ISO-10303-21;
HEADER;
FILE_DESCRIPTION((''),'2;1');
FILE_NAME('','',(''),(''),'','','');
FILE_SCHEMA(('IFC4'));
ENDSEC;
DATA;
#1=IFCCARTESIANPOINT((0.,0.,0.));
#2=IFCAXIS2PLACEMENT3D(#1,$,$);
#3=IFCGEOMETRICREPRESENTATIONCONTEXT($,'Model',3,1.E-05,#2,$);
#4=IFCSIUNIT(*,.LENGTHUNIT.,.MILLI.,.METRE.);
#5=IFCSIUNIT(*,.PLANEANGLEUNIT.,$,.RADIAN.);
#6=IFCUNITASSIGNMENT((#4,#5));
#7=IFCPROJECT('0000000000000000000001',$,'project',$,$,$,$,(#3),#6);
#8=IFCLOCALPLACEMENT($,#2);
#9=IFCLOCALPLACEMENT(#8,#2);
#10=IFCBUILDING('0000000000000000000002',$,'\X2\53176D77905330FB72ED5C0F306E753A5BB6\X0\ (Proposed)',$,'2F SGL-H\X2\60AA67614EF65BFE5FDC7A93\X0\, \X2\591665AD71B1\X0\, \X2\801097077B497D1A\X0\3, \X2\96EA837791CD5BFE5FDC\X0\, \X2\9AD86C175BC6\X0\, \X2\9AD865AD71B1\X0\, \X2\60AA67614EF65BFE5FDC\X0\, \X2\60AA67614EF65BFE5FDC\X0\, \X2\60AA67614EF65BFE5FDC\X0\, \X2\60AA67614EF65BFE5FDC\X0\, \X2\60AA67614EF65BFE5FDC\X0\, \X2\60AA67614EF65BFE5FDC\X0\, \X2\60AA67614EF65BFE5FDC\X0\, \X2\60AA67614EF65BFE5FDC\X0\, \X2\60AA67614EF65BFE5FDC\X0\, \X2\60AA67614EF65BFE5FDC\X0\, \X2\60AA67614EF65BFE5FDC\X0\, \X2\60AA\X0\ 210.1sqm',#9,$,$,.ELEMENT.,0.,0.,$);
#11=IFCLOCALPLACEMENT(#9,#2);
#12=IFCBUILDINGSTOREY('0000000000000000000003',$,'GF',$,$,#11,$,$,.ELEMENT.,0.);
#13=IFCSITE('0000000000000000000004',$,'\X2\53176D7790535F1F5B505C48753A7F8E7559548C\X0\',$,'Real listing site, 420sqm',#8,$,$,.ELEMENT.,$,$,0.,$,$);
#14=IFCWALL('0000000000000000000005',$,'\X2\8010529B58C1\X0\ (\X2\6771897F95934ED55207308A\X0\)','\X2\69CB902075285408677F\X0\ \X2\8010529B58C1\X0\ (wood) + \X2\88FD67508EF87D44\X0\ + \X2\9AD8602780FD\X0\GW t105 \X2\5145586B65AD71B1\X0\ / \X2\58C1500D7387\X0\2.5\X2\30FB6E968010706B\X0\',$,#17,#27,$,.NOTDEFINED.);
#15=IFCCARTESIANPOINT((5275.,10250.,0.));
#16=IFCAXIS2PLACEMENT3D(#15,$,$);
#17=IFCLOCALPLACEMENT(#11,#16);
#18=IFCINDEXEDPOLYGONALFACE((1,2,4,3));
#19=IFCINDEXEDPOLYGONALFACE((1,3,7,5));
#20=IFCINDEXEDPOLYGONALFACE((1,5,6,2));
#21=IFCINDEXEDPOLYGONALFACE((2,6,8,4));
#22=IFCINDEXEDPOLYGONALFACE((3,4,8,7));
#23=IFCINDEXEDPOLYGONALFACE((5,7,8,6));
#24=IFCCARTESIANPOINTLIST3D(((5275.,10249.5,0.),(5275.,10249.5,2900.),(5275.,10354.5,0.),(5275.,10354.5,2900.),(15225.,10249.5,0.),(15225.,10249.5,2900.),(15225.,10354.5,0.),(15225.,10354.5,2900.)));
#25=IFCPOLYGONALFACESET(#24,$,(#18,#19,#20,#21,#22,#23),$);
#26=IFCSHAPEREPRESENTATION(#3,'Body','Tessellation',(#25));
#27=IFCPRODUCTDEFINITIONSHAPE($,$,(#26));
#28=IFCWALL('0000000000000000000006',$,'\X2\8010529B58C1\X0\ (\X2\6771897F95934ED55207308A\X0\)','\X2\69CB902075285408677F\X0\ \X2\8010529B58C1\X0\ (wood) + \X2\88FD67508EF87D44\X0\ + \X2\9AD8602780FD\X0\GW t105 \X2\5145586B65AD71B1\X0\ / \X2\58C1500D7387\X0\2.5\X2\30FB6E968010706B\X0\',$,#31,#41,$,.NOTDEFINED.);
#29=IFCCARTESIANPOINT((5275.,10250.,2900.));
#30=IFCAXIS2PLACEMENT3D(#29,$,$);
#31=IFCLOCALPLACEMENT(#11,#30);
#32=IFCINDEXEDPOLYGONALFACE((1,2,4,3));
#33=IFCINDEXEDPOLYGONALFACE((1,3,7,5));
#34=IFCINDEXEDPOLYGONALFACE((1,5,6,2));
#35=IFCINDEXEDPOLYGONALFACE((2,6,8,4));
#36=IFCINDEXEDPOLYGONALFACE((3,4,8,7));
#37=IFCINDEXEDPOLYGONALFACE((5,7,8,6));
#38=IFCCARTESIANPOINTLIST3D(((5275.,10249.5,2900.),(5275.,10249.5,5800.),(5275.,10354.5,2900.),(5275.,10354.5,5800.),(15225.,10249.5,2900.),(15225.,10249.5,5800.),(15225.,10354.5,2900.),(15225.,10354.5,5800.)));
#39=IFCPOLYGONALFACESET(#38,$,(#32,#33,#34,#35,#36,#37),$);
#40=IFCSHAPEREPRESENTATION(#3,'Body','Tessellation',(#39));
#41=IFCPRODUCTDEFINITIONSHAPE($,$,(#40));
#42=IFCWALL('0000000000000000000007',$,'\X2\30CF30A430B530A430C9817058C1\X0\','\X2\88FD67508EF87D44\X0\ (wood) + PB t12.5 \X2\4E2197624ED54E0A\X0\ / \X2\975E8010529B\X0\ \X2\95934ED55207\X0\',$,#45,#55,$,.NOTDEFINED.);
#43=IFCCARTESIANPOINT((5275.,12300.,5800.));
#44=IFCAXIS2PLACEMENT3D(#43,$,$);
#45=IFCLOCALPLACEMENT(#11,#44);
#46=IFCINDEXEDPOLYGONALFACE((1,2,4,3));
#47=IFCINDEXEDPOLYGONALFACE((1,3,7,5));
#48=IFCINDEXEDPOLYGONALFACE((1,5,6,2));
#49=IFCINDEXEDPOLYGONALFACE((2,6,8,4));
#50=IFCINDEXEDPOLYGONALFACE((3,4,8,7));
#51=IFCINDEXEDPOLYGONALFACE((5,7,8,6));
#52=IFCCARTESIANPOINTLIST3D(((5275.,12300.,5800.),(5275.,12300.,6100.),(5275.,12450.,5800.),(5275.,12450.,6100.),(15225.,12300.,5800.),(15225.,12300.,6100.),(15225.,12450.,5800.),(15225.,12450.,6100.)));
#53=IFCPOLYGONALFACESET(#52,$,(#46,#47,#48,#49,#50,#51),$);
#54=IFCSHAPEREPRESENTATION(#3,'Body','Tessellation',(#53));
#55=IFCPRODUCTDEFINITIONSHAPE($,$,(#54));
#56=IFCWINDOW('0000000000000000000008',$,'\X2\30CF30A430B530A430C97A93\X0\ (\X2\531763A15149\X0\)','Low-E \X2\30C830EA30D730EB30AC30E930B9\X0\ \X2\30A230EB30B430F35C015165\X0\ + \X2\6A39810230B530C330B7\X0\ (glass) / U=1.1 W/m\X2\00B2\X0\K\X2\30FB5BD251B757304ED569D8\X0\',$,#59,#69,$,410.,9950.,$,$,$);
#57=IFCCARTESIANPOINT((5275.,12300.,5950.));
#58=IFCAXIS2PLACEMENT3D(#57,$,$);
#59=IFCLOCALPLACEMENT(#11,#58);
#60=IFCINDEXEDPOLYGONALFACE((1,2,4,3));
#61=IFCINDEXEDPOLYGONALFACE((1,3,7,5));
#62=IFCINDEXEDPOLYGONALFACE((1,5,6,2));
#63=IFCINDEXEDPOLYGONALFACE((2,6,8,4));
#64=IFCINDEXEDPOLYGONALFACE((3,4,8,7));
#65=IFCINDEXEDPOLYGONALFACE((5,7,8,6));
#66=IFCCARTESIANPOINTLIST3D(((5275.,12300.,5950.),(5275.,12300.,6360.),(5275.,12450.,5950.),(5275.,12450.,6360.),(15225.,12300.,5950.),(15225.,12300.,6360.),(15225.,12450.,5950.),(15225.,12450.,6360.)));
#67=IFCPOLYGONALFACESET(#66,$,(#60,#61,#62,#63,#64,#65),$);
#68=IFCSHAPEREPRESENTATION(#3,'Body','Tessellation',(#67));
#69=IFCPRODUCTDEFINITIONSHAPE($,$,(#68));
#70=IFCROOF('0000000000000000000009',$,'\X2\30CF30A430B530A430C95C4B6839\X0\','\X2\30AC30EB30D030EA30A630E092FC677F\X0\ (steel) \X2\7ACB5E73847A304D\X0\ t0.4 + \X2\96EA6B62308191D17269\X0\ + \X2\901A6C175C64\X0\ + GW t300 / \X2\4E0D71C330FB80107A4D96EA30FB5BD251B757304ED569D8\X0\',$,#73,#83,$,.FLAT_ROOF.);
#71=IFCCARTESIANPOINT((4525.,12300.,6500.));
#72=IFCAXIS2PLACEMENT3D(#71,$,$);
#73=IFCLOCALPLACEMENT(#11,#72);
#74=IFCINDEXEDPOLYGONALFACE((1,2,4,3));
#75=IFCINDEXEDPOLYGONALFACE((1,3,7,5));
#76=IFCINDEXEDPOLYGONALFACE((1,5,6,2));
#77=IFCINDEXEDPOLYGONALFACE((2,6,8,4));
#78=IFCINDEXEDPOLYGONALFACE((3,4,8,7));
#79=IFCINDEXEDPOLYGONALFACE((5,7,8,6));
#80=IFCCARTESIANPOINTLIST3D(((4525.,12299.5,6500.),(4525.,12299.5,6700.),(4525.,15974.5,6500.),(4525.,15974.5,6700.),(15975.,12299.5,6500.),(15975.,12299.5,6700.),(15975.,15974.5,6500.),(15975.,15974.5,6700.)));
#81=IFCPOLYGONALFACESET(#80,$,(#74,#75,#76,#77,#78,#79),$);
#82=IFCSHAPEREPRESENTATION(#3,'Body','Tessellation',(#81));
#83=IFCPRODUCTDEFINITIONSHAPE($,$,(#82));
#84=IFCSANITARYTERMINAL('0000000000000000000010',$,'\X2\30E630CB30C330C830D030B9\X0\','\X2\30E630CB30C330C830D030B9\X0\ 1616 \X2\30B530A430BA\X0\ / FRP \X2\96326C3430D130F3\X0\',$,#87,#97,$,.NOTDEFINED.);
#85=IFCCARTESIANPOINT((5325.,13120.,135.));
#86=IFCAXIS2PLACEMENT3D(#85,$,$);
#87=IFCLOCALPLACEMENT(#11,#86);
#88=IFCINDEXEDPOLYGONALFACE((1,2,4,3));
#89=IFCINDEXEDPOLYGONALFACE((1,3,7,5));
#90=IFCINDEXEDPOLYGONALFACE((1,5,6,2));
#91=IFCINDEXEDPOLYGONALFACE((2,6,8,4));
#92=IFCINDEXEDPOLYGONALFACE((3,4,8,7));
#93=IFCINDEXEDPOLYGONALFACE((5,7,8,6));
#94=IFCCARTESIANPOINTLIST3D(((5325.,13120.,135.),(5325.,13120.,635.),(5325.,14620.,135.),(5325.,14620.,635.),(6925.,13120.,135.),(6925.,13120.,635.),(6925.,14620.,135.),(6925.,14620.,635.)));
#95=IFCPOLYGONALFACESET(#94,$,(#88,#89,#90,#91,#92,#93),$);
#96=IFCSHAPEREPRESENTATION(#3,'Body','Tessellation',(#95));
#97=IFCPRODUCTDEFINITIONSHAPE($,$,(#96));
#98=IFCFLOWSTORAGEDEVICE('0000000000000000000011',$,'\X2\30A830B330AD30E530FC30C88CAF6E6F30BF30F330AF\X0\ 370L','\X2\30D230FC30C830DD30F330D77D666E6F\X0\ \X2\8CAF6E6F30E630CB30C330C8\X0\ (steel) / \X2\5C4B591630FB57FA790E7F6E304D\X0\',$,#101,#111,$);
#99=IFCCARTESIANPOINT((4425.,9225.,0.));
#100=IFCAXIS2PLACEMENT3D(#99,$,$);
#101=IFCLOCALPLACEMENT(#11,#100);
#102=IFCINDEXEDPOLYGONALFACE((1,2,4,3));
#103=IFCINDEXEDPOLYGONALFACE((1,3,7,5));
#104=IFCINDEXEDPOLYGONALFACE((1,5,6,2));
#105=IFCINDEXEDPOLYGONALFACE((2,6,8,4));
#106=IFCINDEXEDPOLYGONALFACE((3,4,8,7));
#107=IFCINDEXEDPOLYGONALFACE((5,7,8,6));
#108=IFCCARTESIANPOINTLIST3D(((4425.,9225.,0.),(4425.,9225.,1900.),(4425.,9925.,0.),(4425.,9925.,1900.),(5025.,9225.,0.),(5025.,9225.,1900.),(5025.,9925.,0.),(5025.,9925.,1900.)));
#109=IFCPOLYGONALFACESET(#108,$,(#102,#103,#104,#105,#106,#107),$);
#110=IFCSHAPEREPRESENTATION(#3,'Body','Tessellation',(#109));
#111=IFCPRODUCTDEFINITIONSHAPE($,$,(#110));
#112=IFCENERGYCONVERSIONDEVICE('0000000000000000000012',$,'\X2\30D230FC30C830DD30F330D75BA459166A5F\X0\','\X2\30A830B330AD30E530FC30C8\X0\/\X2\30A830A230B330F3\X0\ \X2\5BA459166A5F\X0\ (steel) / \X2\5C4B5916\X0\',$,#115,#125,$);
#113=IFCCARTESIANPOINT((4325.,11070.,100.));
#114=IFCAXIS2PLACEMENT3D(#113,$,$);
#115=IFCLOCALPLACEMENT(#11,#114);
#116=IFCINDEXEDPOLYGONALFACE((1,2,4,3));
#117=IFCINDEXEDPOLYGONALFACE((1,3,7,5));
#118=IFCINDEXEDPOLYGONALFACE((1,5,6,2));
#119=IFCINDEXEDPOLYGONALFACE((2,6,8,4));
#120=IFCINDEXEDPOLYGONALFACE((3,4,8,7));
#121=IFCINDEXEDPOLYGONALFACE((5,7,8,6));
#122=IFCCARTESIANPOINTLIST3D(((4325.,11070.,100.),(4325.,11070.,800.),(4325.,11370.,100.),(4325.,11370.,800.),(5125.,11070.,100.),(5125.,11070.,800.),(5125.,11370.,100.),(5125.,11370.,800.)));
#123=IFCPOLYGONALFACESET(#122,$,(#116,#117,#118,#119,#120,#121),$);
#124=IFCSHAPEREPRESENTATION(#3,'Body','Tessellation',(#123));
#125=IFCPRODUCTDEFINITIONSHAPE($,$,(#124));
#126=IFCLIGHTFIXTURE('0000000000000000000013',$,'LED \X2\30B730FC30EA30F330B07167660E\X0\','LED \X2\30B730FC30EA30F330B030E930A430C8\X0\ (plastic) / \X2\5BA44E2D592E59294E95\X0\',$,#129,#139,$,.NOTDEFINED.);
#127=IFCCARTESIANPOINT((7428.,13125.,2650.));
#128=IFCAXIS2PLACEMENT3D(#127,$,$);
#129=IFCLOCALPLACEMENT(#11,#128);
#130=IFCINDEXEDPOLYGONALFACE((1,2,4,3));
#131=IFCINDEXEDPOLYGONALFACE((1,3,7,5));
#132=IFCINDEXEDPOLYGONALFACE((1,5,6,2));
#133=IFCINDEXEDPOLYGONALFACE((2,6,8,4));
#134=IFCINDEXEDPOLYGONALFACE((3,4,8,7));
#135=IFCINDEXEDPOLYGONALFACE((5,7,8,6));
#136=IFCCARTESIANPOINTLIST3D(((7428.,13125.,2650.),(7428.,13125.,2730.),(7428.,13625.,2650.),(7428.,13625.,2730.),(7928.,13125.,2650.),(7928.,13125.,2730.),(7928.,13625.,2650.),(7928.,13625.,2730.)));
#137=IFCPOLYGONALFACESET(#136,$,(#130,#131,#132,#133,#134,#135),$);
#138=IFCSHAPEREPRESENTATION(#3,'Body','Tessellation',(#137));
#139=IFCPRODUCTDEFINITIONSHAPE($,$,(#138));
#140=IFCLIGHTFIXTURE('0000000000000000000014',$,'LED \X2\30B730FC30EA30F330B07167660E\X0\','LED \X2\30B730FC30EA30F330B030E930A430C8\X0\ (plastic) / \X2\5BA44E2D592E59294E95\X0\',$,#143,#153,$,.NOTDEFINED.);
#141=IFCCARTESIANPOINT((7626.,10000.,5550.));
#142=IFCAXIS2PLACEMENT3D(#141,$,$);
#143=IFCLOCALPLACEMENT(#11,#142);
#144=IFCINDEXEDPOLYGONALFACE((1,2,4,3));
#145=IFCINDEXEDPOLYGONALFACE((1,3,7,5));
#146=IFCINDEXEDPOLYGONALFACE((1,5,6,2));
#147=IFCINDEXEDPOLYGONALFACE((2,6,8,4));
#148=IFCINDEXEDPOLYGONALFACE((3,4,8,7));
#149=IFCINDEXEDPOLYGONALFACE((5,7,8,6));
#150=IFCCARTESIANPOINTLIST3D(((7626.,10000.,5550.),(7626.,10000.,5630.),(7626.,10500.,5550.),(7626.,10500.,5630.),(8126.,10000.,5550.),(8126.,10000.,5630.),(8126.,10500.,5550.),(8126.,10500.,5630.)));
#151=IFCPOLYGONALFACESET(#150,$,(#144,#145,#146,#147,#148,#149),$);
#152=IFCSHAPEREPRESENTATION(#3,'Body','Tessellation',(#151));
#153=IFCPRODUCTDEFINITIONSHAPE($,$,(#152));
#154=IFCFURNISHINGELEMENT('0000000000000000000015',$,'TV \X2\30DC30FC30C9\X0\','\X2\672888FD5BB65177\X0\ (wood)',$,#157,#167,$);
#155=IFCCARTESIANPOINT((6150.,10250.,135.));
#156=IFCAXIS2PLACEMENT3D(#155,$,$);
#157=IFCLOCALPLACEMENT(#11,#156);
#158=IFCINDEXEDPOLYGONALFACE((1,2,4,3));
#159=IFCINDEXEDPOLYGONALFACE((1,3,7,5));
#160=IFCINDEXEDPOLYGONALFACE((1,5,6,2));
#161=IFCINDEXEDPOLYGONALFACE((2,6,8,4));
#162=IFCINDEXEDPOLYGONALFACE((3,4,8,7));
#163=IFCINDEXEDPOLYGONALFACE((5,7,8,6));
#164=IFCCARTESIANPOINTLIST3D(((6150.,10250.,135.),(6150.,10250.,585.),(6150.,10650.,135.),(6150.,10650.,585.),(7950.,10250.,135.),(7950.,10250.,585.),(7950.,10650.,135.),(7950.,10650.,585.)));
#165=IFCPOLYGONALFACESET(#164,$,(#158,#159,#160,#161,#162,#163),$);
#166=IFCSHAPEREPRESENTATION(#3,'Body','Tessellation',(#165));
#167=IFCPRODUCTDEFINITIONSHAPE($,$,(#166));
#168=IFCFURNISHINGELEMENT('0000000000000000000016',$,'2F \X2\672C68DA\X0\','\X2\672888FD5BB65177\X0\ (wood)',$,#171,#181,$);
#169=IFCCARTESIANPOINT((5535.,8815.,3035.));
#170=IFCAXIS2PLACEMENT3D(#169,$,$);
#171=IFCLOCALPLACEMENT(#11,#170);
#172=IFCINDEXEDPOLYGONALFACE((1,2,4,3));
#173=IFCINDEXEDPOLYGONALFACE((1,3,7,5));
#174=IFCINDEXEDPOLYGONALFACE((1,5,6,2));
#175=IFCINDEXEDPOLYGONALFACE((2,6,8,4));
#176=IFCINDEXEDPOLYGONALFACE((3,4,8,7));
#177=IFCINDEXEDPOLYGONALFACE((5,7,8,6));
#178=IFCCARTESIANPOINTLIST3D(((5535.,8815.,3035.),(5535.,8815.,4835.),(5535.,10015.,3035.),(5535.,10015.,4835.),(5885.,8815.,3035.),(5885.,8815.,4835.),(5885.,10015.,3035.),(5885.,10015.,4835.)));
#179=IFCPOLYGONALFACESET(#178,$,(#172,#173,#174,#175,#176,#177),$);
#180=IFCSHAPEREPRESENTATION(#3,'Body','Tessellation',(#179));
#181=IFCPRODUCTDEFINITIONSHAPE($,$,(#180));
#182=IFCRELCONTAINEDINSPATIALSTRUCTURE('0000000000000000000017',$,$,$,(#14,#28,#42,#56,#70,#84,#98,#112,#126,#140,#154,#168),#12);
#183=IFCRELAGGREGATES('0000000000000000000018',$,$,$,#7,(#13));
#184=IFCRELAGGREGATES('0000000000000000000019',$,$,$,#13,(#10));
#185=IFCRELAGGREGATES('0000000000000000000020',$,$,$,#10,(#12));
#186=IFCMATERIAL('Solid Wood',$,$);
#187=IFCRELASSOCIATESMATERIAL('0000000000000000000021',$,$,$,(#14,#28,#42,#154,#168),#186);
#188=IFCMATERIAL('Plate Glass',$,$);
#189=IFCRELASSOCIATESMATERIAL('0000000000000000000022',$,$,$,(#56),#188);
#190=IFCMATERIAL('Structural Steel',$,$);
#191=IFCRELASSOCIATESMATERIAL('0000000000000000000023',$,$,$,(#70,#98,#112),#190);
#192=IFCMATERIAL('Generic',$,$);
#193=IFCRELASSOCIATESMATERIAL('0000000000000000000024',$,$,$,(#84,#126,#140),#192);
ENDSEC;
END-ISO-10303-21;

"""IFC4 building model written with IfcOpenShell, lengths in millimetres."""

from ifc_helpers import new_model, si_unit, frame, frame_2d, origin, place, context, project, spatial, rectangle, extrude, material, element, fill, save


model = new_model("IFC4")

# Units and contexts
model_context = context("Model", 3, precision=1e-05, world=origin())
ifc_project = project(units=[si_unit("LENGTHUNIT", "METRE", prefix="MILLI"), si_unit("PLANEANGLEUNIT", "RADIAN")], contexts=[model_context])

# Site, building, storey
site_placement = place(None, origin())
site = spatial("IfcSite", under=ifc_project, at=site_placement, Name="北海道弟子屈町美留和", ObjectType="Real listing site, 420sqm", CompositionType="ELEMENT", RefElevation=0.0)
building_placement = place(site_placement, origin())
building = spatial("IfcBuilding", under=site, at=building_placement, Name="北海道・狭小の町家 (Proposed)", ObjectType="2F SGL-H悪条件対応窓, 外断熱, 耐震等級3, 雪荷重対応, 高気密, 高断熱, 悪条件対応, 悪条件対応, 悪条件対応, 悪条件対応, 悪条件対応, 悪条件対応, 悪条件対応, 悪条件対応, 悪条件対応, 悪条件対応, 悪条件対応, 悪 210.1sqm", CompositionType="ELEMENT", ElevationOfRefHeight=0.0, ElevationOfTerrain=0.0)
storey_placement = place(building_placement, origin())
storey = spatial("IfcBuildingStorey", under=building, at=storey_placement, Name="GF", CompositionType="ELEMENT", Elevation=0.0)

# Shared definitions
ifc_material_1 = material(Name="Solid Wood")

# Wall
wall_1_placement = place(storey_placement, frame((5275.0, 10250.0, 0.0)))
element("IfcWall", 1, at=wall_1_placement, inside=storey, material=ifc_material_1, Name="耐力壁 (東西間仕切り)", Description="構造用合板 耐力壁 (wood) + 製材軸組 + 高性能GW t105 充填断熱 / 壁倍率2.5・準耐火", PredefinedType="NOTDEFINED", context=model_context, shape_type="SweptSolid", body=[
    extrude(rectangle(XDim=9950.0, YDim=105.0, at=frame_2d((4975.0, 52.0))), frame((5275.0, 10250.0, 0.0)), (0.0, 0.0, 1.0), 2900.0),
])

# Wall
wall_2_placement = place(storey_placement, frame((5275.0, 10250.0, 2900.0)))
element("IfcWall", 2, at=wall_2_placement, inside=storey, material=ifc_material_1, Name="耐力壁 (東西間仕切り)", Description="構造用合板 耐力壁 (wood) + 製材軸組 + 高性能GW t105 充填断熱 / 壁倍率2.5・準耐火", PredefinedType="NOTDEFINED", context=model_context, shape_type="SweptSolid", body=[
    extrude(rectangle(XDim=9950.0, YDim=105.0, at=frame_2d((4975.0, 52.0))), frame((5275.0, 10250.0, 2900.0)), (0.0, 0.0, 1.0), 2900.0),
])

# Wall, opening, window
wall_3_placement = place(storey_placement, frame((5275.0, 12300.0, 5800.0)))
wall_3 = element("IfcWall", 3, at=wall_3_placement, inside=storey, material=ifc_material_1, Name="ハイサイド腰壁", Description="製材軸組 (wood) + PB t12.5 両面仕上 / 非耐力 間仕切", PredefinedType="NOTDEFINED", context=model_context, shape_type="SweptSolid", body=[
    extrude(rectangle(XDim=9950.0, YDim=150.0, at=frame_2d((4975.0, 75.0))), frame((5275.0, 12300.0, 5800.0)), (0.0, 0.0, 1.0), 700.0),
])
opening_1_placement = place(storey_placement, frame((5275.0, 12300.0, 5950.0)))
opening_1 = element("IfcOpeningElement", 4, at=opening_1_placement, cuts=wall_3, PredefinedType="NOTDEFINED", context=model_context, shape_type="SweptSolid", body=[
    extrude(rectangle(XDim=9950.0, YDim=150.0, at=frame_2d((4975.0, 75.0))), frame((5275.0, 12300.0, 5950.0)), (0.0, 0.0, 1.0), 410.0),
])
ifc_material_2 = material(Name="Plate Glass")
window_placement = place(storey_placement, frame((5275.0, 12300.0, 5950.0)))
window = element("IfcWindow", 5, at=window_placement, inside=storey, material=ifc_material_2, Name="ハイサイド窓 (北採光)", Description="Low-E トリプルガラス アルゴン封入 + 樹脂サッシ (glass) / U=1.1 W/m²K・寒冷地仕様", OverallHeight=410.0, OverallWidth=9950.0, context=model_context, shape_type="SweptSolid", body=[
    extrude(rectangle(XDim=9950.0, YDim=150.0, at=frame_2d((4975.0, 75.0))), frame((5275.0, 12300.0, 5950.0)), (0.0, 0.0, 1.0), 410.0),
])
fill(opening_1, window)

# Roof
ifc_material_3 = material(Name="Structural Steel")
roof_placement = place(storey_placement, frame((4525.0, 12300.0, 6500.0)))
element("IfcRoof", 6, at=roof_placement, inside=storey, material=ifc_material_3, Name="ハイサイド屋根", Description="ガルバリウム鋼板 (steel) 立平葺き t0.4 + 雪止め金物 + 通気層 + GW t300 / 不燃・耐積雪・寒冷地仕様", PredefinedType="FLAT_ROOF", context=model_context, shape_type="SweptSolid", body=[
    extrude(rectangle(XDim=11450.0, YDim=3675.0, at=frame_2d((5725.0, 1837.0))), frame((4525.0, 12300.0, 6500.0)), (0.0, 0.0, 1.0), 200.0),
])

# Sanitary terminal
ifc_material_4 = material(Name="Generic")
sanitary_terminal_placement = place(storey_placement, frame((5325.0, 13120.0, 135.0)))
element("IfcSanitaryTerminal", 7, at=sanitary_terminal_placement, inside=storey, material=ifc_material_4, Name="ユニットバス", Description="ユニットバス 1616 サイズ / FRP 防水パン", PredefinedType="NOTDEFINED", context=model_context, shape_type="SweptSolid", body=[
    extrude(rectangle(XDim=1600.0, YDim=1500.0, at=frame_2d((800.0, 750.0))), frame((5325.0, 13120.0, 135.0)), (0.0, 0.0, 1.0), 500.0),
])

# Flow storage device
flow_storage_device_placement = place(storey_placement, frame((4425.0, 9225.0, 0.0)))
element("IfcFlowStorageDevice", 8, at=flow_storage_device_placement, inside=storey, material=ifc_material_3, Name="エコキュート貯湯タンク 370L", Description="ヒートポンプ給湯 貯湯ユニット (steel) / 屋外・基礎置き", context=model_context, shape_type="SweptSolid", body=[
    extrude(rectangle(XDim=600.0, YDim=700.0, at=frame_2d((300.0, 350.0))), frame((4425.0, 9225.0, 0.0)), (0.0, 0.0, 1.0), 1900.0),
])

# Energy conversion device
energy_conversion_device_placement = place(storey_placement, frame((4325.0, 11070.0, 100.0)))
element("IfcEnergyConversionDevice", 9, at=energy_conversion_device_placement, inside=storey, material=ifc_material_3, Name="ヒートポンプ室外機", Description="エコキュート/エアコン 室外機 (steel) / 屋外", context=model_context, shape_type="SweptSolid", body=[
    extrude(rectangle(XDim=800.0, YDim=300.0, at=frame_2d((400.0, 150.0))), frame((4325.0, 11070.0, 100.0)), (0.0, 0.0, 1.0), 700.0),
])

# Light fixtures
light_fixture_1_placement = place(storey_placement, frame((7428.0, 13125.0, 2650.0)))
element("IfcLightFixture", 10, at=light_fixture_1_placement, inside=storey, material=ifc_material_4, Name="LED シーリング照明", Description="LED シーリングライト (plastic) / 室中央天井", PredefinedType="NOTDEFINED", context=model_context, shape_type="SweptSolid", body=[
    extrude(rectangle(XDim=500.0, YDim=500.0, at=frame_2d((250.0, 250.0))), frame((7428.0, 13125.0, 2650.0)), (0.0, 0.0, 1.0), 80.0),
])
light_fixture_2_placement = place(storey_placement, frame((7626.0, 10000.0, 5550.0)))
element("IfcLightFixture", 11, at=light_fixture_2_placement, inside=storey, material=ifc_material_4, Name="LED シーリング照明", Description="LED シーリングライト (plastic) / 室中央天井", PredefinedType="NOTDEFINED", context=model_context, shape_type="SweptSolid", body=[
    extrude(rectangle(XDim=500.0, YDim=500.0, at=frame_2d((250.0, 250.0))), frame((7626.0, 10000.0, 5550.0)), (0.0, 0.0, 1.0), 80.0),
])

# Furnishing elements
furnishing_1_placement = place(storey_placement, frame((6150.0, 10250.0, 135.0)))
element("IfcFurnishingElement", 12, at=furnishing_1_placement, inside=storey, material=ifc_material_1, Name="TV ボード", Description="木製家具 (wood)", context=model_context, shape_type="SweptSolid", body=[
    extrude(rectangle(XDim=1800.0, YDim=400.0, at=frame_2d((900.0, 200.0))), frame((6150.0, 10250.0, 135.0)), (0.0, 0.0, 1.0), 450.0),
])
furnishing_2_placement = place(storey_placement, frame((5535.0, 8815.0, 3035.0)))
element("IfcFurnishingElement", 13, at=furnishing_2_placement, inside=storey, material=ifc_material_1, Name="2F 本棚", Description="木製家具 (wood)", context=model_context, shape_type="SweptSolid", body=[
    extrude(rectangle(XDim=350.0, YDim=1200.0, at=frame_2d((175.0, 600.0))), frame((5535.0, 8815.0, 3035.0)), (0.0, 0.0, 1.0), 1800.0),
])

save(model, "model.ifc")
